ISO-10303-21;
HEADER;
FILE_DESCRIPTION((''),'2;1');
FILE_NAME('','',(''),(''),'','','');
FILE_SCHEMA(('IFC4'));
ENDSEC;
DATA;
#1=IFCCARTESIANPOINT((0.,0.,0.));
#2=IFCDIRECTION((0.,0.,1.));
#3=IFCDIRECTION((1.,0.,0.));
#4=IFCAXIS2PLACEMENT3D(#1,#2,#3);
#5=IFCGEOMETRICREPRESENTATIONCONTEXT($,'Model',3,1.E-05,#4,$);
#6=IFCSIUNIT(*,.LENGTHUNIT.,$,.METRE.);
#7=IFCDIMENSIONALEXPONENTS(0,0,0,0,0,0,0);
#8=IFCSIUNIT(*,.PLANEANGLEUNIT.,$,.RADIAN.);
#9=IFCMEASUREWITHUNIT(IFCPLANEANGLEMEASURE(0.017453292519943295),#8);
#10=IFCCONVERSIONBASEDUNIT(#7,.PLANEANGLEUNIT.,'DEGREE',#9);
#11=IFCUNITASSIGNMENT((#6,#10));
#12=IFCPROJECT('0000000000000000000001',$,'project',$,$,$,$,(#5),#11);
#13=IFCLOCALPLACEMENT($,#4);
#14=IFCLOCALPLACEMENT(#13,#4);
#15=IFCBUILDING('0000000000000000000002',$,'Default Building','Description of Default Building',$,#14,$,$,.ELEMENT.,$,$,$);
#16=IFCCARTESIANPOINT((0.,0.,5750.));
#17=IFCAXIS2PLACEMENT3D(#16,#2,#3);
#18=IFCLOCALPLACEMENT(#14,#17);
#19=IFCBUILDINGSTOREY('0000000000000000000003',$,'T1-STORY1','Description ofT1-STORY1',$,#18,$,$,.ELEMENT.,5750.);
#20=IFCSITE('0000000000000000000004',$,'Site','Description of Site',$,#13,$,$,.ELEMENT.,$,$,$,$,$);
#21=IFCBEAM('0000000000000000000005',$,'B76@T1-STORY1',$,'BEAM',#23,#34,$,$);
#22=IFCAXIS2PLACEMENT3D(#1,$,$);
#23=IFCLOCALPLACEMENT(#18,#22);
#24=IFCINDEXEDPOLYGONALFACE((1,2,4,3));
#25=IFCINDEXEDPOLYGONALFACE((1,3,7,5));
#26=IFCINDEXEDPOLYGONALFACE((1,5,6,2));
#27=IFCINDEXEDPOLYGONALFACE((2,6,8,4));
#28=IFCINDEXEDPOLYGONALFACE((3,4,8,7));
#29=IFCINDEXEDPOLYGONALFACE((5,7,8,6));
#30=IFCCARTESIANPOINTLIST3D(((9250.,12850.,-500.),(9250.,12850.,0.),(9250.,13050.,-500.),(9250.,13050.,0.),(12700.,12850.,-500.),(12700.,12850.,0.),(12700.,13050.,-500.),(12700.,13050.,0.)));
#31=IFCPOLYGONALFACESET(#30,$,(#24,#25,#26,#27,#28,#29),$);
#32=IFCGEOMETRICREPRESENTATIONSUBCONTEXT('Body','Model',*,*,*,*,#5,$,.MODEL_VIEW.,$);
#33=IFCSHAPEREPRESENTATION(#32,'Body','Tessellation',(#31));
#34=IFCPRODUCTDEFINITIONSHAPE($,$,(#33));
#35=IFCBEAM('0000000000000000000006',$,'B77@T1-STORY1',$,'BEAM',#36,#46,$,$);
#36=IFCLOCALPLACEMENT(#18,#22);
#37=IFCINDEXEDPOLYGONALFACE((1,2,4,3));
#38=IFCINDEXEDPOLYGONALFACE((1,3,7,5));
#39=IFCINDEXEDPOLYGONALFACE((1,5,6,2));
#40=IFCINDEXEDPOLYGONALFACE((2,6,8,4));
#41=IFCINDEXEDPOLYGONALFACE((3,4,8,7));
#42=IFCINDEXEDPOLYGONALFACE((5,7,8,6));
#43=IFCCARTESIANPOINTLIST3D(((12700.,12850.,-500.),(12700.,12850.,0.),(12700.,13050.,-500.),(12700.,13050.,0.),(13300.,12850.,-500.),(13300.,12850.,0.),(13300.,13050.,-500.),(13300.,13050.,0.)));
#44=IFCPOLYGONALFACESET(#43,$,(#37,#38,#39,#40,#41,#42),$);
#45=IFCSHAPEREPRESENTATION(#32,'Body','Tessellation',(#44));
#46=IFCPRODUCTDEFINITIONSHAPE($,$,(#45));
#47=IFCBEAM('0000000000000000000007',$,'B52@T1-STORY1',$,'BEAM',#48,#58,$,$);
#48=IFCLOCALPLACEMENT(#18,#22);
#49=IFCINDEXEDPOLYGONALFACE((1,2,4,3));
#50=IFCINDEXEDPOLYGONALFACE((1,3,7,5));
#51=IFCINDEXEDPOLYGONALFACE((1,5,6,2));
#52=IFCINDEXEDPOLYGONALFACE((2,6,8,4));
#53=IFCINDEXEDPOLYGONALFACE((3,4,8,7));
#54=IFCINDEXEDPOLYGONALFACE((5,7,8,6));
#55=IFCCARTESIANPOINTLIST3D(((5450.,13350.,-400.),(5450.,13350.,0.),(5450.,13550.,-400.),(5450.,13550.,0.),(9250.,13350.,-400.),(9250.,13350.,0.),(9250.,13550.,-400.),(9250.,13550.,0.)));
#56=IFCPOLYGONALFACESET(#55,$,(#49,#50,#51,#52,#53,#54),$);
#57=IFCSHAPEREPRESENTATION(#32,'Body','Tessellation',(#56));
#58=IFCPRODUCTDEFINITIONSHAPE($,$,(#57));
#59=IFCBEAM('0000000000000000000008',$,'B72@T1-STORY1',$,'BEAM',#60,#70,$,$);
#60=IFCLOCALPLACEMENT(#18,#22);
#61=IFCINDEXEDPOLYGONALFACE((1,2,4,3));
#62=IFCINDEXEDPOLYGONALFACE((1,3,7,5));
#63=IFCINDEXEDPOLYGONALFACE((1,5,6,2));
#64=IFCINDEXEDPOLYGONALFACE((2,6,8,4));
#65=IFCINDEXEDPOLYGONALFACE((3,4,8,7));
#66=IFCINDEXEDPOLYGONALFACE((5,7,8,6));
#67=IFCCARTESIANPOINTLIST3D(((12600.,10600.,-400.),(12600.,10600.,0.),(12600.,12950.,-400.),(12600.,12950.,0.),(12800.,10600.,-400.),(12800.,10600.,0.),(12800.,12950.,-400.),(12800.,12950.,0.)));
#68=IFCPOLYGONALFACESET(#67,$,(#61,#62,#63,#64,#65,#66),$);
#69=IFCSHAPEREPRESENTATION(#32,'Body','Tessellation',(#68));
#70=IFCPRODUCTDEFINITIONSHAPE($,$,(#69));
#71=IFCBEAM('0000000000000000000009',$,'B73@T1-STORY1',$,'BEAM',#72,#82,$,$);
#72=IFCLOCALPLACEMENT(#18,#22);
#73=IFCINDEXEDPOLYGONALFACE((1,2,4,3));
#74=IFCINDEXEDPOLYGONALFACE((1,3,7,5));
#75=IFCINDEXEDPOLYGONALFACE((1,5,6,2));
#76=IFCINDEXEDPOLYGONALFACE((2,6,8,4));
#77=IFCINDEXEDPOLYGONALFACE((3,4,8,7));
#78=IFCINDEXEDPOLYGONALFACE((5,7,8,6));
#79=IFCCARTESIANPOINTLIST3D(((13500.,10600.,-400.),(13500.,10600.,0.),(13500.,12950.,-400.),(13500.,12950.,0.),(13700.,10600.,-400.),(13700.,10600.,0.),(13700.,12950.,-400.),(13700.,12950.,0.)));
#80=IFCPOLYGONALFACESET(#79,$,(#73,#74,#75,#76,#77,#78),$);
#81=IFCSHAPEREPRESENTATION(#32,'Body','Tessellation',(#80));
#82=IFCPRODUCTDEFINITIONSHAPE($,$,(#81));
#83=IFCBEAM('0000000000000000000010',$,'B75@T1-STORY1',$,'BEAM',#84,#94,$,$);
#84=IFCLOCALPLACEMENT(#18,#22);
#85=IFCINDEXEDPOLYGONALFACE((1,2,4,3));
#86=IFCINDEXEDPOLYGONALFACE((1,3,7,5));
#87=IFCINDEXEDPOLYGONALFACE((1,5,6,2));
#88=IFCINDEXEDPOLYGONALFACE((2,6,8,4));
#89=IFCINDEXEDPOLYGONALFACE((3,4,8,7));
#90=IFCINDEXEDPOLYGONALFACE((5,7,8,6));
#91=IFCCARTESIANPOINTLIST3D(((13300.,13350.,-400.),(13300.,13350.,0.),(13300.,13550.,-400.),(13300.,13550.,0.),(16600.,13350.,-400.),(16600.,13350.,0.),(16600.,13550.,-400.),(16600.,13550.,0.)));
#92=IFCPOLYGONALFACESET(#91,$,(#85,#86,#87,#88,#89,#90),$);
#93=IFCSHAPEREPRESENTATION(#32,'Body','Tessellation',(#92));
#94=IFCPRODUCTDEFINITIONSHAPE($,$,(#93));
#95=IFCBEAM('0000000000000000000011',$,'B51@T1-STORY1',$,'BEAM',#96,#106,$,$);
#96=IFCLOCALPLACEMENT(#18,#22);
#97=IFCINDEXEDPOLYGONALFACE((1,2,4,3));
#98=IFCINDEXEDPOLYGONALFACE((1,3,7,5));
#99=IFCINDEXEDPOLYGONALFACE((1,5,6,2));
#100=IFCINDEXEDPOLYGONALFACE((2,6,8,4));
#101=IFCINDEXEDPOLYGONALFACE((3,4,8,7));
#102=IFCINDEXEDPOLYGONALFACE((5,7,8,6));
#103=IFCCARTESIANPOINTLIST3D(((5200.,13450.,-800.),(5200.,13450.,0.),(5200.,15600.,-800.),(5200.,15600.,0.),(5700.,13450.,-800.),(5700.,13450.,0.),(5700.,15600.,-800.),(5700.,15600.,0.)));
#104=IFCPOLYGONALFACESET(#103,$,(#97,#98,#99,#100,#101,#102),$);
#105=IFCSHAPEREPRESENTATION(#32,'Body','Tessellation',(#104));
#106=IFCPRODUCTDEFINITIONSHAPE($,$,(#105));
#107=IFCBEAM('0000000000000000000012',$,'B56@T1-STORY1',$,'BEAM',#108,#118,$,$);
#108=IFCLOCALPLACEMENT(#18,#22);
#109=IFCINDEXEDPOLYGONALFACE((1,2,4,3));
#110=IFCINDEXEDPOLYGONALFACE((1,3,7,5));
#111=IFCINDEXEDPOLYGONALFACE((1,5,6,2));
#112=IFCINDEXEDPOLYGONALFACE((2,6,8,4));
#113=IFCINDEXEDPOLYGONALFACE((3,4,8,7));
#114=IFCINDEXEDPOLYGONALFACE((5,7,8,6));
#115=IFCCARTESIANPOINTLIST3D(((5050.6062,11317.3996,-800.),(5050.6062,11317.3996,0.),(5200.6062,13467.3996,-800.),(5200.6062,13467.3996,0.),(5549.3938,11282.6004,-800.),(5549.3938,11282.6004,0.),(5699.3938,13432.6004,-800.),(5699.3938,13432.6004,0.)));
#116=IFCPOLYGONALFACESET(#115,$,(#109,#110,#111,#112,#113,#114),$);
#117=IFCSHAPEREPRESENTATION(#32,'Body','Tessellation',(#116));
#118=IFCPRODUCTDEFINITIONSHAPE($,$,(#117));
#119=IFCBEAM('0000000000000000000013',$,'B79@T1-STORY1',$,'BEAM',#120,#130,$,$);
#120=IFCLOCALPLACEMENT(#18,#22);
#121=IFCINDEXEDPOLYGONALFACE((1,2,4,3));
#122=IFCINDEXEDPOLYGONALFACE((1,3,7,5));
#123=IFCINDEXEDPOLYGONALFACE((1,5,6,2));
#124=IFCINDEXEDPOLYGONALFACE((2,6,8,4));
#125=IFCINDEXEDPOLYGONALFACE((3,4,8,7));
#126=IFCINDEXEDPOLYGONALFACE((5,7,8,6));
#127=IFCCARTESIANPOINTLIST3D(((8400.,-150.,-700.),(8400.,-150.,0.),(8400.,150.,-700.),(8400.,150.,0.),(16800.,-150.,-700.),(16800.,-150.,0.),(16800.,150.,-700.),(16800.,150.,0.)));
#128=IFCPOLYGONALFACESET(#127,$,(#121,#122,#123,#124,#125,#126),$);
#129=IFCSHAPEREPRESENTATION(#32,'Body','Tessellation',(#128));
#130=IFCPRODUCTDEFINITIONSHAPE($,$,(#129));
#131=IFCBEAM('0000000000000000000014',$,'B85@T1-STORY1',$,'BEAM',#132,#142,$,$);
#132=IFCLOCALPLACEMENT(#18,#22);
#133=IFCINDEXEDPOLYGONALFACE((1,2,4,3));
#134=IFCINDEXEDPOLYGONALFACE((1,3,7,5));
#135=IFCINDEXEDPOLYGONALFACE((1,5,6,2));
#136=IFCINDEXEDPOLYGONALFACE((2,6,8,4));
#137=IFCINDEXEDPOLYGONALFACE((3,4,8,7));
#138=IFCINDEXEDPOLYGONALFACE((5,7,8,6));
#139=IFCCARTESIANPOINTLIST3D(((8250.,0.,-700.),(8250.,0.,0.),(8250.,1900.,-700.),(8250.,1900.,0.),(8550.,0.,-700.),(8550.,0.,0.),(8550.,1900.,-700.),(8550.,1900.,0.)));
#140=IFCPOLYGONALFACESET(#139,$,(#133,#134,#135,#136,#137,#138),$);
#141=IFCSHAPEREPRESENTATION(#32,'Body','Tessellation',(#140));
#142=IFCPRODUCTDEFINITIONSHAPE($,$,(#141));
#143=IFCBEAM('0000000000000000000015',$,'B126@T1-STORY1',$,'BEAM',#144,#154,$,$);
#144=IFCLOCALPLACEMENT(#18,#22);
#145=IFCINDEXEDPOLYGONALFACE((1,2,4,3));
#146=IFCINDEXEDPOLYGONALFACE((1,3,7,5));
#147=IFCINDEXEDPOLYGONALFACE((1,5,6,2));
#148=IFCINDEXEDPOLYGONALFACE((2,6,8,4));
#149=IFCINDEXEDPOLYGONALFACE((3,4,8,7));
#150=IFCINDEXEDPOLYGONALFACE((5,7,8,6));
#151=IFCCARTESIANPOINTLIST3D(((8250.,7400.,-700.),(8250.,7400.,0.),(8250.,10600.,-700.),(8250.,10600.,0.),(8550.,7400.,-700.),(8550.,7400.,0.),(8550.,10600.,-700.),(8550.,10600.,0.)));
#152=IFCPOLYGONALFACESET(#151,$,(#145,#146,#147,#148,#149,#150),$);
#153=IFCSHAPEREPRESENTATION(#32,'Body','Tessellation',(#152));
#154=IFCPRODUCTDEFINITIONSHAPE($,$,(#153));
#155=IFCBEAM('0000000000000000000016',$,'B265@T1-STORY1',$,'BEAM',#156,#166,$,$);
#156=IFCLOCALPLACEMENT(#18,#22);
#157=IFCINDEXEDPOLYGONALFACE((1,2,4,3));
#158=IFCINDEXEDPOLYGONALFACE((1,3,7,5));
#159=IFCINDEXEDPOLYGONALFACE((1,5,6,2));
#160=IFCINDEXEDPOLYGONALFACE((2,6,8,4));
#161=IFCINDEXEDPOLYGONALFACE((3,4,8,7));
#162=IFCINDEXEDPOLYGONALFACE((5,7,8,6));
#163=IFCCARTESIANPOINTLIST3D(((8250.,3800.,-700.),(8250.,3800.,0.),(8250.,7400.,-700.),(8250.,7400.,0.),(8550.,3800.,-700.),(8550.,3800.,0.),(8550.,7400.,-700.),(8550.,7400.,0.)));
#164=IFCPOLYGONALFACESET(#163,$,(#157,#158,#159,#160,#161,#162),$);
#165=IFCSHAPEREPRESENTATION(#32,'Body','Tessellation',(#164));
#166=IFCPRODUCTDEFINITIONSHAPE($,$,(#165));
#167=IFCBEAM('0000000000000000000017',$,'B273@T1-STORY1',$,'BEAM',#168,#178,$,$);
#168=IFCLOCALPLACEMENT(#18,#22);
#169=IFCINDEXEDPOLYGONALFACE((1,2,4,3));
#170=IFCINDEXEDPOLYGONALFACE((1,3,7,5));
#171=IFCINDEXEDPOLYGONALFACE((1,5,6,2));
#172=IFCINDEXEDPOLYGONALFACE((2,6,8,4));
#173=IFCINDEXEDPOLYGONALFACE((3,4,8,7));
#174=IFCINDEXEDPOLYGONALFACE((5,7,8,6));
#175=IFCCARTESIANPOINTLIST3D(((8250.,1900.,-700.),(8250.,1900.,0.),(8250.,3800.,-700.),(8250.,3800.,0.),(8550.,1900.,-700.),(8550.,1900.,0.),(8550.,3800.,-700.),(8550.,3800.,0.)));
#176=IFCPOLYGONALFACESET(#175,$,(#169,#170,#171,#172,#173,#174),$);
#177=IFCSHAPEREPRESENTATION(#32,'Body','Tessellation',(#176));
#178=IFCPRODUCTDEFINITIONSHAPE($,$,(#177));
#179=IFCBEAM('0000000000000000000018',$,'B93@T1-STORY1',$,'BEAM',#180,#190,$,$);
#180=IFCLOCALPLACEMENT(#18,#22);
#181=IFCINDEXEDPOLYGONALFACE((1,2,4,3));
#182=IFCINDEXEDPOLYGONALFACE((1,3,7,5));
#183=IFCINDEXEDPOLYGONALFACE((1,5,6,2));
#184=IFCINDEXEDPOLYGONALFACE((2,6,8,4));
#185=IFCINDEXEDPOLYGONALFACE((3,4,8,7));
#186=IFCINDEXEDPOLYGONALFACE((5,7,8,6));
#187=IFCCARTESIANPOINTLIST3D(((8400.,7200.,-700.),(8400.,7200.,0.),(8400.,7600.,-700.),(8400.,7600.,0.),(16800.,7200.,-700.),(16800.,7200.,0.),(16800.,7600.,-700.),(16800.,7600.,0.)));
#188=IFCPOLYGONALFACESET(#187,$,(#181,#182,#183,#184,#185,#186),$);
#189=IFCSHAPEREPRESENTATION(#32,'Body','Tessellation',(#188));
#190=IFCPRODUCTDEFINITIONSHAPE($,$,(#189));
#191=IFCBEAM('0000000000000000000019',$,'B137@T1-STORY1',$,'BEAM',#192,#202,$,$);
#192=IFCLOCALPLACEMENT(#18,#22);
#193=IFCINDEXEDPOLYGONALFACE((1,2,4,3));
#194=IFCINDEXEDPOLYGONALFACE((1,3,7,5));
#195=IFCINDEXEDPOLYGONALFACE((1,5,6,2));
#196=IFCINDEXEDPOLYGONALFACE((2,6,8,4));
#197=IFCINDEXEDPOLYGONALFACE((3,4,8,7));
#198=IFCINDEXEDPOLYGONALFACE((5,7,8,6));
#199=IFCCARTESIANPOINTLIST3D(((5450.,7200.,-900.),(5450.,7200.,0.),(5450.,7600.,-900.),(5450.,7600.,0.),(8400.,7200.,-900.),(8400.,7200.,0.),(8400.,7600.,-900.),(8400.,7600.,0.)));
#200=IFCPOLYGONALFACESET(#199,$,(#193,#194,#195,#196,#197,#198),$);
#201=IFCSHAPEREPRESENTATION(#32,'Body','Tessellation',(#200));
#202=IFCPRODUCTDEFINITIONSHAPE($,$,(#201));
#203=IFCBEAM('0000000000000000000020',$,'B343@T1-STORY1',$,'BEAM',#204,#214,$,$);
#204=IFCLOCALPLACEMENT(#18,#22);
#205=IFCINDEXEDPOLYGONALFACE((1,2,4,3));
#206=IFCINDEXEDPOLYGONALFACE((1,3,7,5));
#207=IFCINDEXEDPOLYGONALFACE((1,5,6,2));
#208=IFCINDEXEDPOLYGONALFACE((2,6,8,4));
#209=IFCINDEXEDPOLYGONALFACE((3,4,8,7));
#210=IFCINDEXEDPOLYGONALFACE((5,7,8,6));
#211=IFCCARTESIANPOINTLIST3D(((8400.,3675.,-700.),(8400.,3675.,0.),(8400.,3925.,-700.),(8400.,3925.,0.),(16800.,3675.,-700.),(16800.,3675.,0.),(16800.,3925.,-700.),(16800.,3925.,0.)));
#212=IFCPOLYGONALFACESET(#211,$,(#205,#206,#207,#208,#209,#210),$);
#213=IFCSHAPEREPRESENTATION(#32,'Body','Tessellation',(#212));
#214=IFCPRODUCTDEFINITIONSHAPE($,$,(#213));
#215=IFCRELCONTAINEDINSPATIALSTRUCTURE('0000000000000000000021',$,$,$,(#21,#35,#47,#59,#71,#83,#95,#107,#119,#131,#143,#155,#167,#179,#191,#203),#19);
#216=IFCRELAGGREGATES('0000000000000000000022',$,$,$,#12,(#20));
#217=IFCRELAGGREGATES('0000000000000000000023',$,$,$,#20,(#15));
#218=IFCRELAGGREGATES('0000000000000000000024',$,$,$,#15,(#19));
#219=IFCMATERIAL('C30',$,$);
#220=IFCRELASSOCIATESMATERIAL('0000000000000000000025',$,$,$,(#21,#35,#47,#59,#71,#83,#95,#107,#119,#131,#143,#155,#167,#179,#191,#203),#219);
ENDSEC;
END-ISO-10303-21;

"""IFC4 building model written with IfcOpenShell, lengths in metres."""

from ifc_helpers import new_model, entity, si_unit, converted_unit, frame, origin_with_axes, place, context, subcontext, project, spatial, rectangle, extrude, material, element, save


model = new_model("IFC4")

# Units and contexts
model_context = context("Model", 3, precision=1e-05, world=origin_with_axes())
body_context = subcontext(model_context, "Body", "Model", "MODEL_VIEW")
ifc_project = project(units=[si_unit("LENGTHUNIT", "METRE"), converted_unit("PLANEANGLEUNIT", "DEGREE", entity("IfcPlaneAngleMeasure", 0.017453292519943295), si_unit("PLANEANGLEUNIT", "RADIAN"), dimensions=[0, 0, 0, 0, 0, 0, 0])], contexts=[model_context])

# Site, building, storey
site_placement = place(None, origin_with_axes())
site = spatial("IfcSite", under=ifc_project, at=site_placement, Name="Site", Description="Description of Site", CompositionType="ELEMENT")
building_placement = place(site_placement, origin_with_axes())
building = spatial("IfcBuilding", under=site, at=building_placement, Name="Default Building", Description="Description of Default Building", CompositionType="ELEMENT")
storey_placement = place(building_placement, frame((0.0, 0.0, 5750.0), z_axis=(0.0, 0.0, 1.0), x_axis=(1.0, 0.0, 0.0)))
storey = spatial("IfcBuildingStorey", under=building, at=storey_placement, Name="T1-STORY1", Description="Description ofT1-STORY1", CompositionType="ELEMENT", Elevation=5750.0)

# Beams
ifc_material_1 = material(Name="C30")
beam_1_placement = place(storey_placement, frame((9250.0, 12950.0, -250.0), z_axis=(1.0, 0.0, 0.0), x_axis=(0.0, 1.0, 0.0)))
element("IfcBeam", 1, at=beam_1_placement, inside=storey, material=ifc_material_1, Name="B76@T1-STORY1", ObjectType="BEAM", context=body_context, shape_type="SweptSolid", body=[
    extrude(rectangle(XDim=200.0, YDim=500.0), origin_with_axes(), (0.0, 0.0, 1.0), 3450.0),
])
beam_2_placement = place(storey_placement, frame((12700.0, 12950.0, -250.0), z_axis=(1.0, 0.0, 0.0), x_axis=(0.0, 1.0, 0.0)))
element("IfcBeam", 2, at=beam_2_placement, inside=storey, material=ifc_material_1, Name="B77@T1-STORY1", ObjectType="BEAM", context=body_context, shape_type="SweptSolid", body=[
    extrude(rectangle(XDim=200.0, YDim=500.0), origin_with_axes(), (0.0, 0.0, 1.0), 600.0),
])
beam_3_placement = place(storey_placement, frame((5450.0, 13450.0, -200.0), z_axis=(1.0, 0.0, 0.0), x_axis=(0.0, 1.0, 0.0)))
element("IfcBeam", 3, at=beam_3_placement, inside=storey, material=ifc_material_1, Name="B52@T1-STORY1", ObjectType="BEAM", context=body_context, shape_type="SweptSolid", body=[
    extrude(rectangle(XDim=200.0, YDim=400.0), origin_with_axes(), (0.0, 0.0, 1.0), 3800.0),
])
for number, where, z_axis, x_axis, name in (
    (4, (12700.0, 10600.0, -200.0), (0.0, 1.0, 0.0), (-1.0, 0.0, 0.0), "B72@T1-STORY1"),
    (5, (13600.0, 10600.0, -200.0), (0.0, 1.0, 0.0), (-1.0, 0.0, 0.0), "B73@T1-STORY1"),
):
    element("IfcBeam", number, at=place(storey_placement, frame(where, z_axis=z_axis, x_axis=x_axis)), inside=storey, material=ifc_material_1, Name=name, ObjectType="BEAM", context=body_context, shape_type="SweptSolid", body=[
        extrude(rectangle(XDim=200.0, YDim=400.0), origin_with_axes(), (0.0, 0.0, 1.0), 2350.0),
    ])
beam_4_placement = place(storey_placement, frame((13300.0, 13450.0, -200.0), z_axis=(1.0, 0.0, 0.0), x_axis=(0.0, 1.0, 0.0)))
element("IfcBeam", 6, at=beam_4_placement, inside=storey, material=ifc_material_1, Name="B75@T1-STORY1", ObjectType="BEAM", context=body_context, shape_type="SweptSolid", body=[
    extrude(rectangle(XDim=200.0, YDim=400.0), origin_with_axes(), (0.0, 0.0, 1.0), 3300.0),
])
beam_5_placement = place(storey_placement, frame((5450.0, 13450.0, -400.0), z_axis=(0.0, 1.0, 0.0), x_axis=(-1.0, 0.0, 0.0)))
element("IfcBeam", 7, at=beam_5_placement, inside=storey, material=ifc_material_1, Name="B51@T1-STORY1", ObjectType="BEAM", context=body_context, shape_type="SweptSolid", body=[
    extrude(rectangle(XDim=500.0, YDim=800.0), origin_with_axes(), (0.0, 0.0, 1.0), 2150.0),
])
beam_6_placement = place(storey_placement, frame((5300.0, 11300.0, -400.0), z_axis=(0.069598, 0.997575, 0.0), x_axis=(-0.997575, 0.069598, 0.0)))
element("IfcBeam", 8, at=beam_6_placement, inside=storey, material=ifc_material_1, Name="B56@T1-STORY1", ObjectType="BEAM", context=body_context, shape_type="SweptSolid", body=[
    extrude(rectangle(XDim=500.0, YDim=800.0), origin_with_axes(), (0.0, 0.0, 1.0), 2155.2262),
])
beam_7_placement = place(storey_placement, frame((8400.0, 0.0, -350.0), z_axis=(1.0, 0.0, 0.0), x_axis=(0.0, 1.0, 0.0)))
element("IfcBeam", 9, at=beam_7_placement, inside=storey, material=ifc_material_1, Name="B79@T1-STORY1", ObjectType="BEAM", context=body_context, shape_type="SweptSolid", body=[
    extrude(rectangle(XDim=300.0, YDim=700.0), origin_with_axes(), (0.0, 0.0, 1.0), 8400.0),
])
beam_8_placement = place(storey_placement, frame((8400.0, 0.0, -350.0), z_axis=(0.0, 1.0, 0.0), x_axis=(-1.0, 0.0, 0.0)))
element("IfcBeam", 10, at=beam_8_placement, inside=storey, material=ifc_material_1, Name="B85@T1-STORY1", ObjectType="BEAM", context=body_context, shape_type="SweptSolid", body=[
    extrude(rectangle(XDim=300.0, YDim=700.0), origin_with_axes(), (0.0, 0.0, 1.0), 1900.0),
])
beam_9_placement = place(storey_placement, frame((8400.0, 7400.0, -350.0), z_axis=(0.0, 1.0, 0.0), x_axis=(-1.0, 0.0, 0.0)))
element("IfcBeam", 11, at=beam_9_placement, inside=storey, material=ifc_material_1, Name="B126@T1-STORY1", ObjectType="BEAM", context=body_context, shape_type="SweptSolid", body=[
    extrude(rectangle(XDim=300.0, YDim=700.0), origin_with_axes(), (0.0, 0.0, 1.0), 3200.0),
])
beam_10_placement = place(storey_placement, frame((8400.0, 3800.0, -350.0), z_axis=(0.0, 1.0, 0.0), x_axis=(-1.0, 0.0, 0.0)))
element("IfcBeam", 12, at=beam_10_placement, inside=storey, material=ifc_material_1, Name="B265@T1-STORY1", ObjectType="BEAM", context=body_context, shape_type="SweptSolid", body=[
    extrude(rectangle(XDim=300.0, YDim=700.0), origin_with_axes(), (0.0, 0.0, 1.0), 3600.0),
])
beam_11_placement = place(storey_placement, frame((8400.0, 1900.0, -350.0), z_axis=(0.0, 1.0, 0.0), x_axis=(-1.0, 0.0, 0.0)))
element("IfcBeam", 13, at=beam_11_placement, inside=storey, material=ifc_material_1, Name="B273@T1-STORY1", ObjectType="BEAM", context=body_context, shape_type="SweptSolid", body=[
    extrude(rectangle(XDim=300.0, YDim=700.0), origin_with_axes(), (0.0, 0.0, 1.0), 1900.0),
])
beam_12_placement = place(storey_placement, frame((8400.0, 7400.0, -350.0), z_axis=(1.0, 0.0, 0.0), x_axis=(0.0, 1.0, 0.0)))
element("IfcBeam", 14, at=beam_12_placement, inside=storey, material=ifc_material_1, Name="B93@T1-STORY1", ObjectType="BEAM", context=body_context, shape_type="SweptSolid", body=[
    extrude(rectangle(XDim=400.0, YDim=700.0), origin_with_axes(), (0.0, 0.0, 1.0), 8400.0),
])
beam_13_placement = place(storey_placement, frame((5450.0, 7400.0, -450.0), z_axis=(1.0, 0.0, 0.0), x_axis=(0.0, 1.0, 0.0)))
element("IfcBeam", 15, at=beam_13_placement, inside=storey, material=ifc_material_1, Name="B137@T1-STORY1", ObjectType="BEAM", context=body_context, shape_type="SweptSolid", body=[
    extrude(rectangle(XDim=400.0, YDim=900.0), origin_with_axes(), (0.0, 0.0, 1.0), 2950.0),
])
beam_14_placement = place(storey_placement, frame((8400.0, 3800.0, -350.0), z_axis=(1.0, 0.0, 0.0), x_axis=(0.0, 1.0, 0.0)))
element("IfcBeam", 16, at=beam_14_placement, inside=storey, material=ifc_material_1, Name="B343@T1-STORY1", ObjectType="BEAM", context=body_context, shape_type="SweptSolid", body=[
    extrude(rectangle(XDim=250.0, YDim=700.0), origin_with_axes(), (0.0, 0.0, 1.0), 8400.0),
])

save(model, "model.ifc")
